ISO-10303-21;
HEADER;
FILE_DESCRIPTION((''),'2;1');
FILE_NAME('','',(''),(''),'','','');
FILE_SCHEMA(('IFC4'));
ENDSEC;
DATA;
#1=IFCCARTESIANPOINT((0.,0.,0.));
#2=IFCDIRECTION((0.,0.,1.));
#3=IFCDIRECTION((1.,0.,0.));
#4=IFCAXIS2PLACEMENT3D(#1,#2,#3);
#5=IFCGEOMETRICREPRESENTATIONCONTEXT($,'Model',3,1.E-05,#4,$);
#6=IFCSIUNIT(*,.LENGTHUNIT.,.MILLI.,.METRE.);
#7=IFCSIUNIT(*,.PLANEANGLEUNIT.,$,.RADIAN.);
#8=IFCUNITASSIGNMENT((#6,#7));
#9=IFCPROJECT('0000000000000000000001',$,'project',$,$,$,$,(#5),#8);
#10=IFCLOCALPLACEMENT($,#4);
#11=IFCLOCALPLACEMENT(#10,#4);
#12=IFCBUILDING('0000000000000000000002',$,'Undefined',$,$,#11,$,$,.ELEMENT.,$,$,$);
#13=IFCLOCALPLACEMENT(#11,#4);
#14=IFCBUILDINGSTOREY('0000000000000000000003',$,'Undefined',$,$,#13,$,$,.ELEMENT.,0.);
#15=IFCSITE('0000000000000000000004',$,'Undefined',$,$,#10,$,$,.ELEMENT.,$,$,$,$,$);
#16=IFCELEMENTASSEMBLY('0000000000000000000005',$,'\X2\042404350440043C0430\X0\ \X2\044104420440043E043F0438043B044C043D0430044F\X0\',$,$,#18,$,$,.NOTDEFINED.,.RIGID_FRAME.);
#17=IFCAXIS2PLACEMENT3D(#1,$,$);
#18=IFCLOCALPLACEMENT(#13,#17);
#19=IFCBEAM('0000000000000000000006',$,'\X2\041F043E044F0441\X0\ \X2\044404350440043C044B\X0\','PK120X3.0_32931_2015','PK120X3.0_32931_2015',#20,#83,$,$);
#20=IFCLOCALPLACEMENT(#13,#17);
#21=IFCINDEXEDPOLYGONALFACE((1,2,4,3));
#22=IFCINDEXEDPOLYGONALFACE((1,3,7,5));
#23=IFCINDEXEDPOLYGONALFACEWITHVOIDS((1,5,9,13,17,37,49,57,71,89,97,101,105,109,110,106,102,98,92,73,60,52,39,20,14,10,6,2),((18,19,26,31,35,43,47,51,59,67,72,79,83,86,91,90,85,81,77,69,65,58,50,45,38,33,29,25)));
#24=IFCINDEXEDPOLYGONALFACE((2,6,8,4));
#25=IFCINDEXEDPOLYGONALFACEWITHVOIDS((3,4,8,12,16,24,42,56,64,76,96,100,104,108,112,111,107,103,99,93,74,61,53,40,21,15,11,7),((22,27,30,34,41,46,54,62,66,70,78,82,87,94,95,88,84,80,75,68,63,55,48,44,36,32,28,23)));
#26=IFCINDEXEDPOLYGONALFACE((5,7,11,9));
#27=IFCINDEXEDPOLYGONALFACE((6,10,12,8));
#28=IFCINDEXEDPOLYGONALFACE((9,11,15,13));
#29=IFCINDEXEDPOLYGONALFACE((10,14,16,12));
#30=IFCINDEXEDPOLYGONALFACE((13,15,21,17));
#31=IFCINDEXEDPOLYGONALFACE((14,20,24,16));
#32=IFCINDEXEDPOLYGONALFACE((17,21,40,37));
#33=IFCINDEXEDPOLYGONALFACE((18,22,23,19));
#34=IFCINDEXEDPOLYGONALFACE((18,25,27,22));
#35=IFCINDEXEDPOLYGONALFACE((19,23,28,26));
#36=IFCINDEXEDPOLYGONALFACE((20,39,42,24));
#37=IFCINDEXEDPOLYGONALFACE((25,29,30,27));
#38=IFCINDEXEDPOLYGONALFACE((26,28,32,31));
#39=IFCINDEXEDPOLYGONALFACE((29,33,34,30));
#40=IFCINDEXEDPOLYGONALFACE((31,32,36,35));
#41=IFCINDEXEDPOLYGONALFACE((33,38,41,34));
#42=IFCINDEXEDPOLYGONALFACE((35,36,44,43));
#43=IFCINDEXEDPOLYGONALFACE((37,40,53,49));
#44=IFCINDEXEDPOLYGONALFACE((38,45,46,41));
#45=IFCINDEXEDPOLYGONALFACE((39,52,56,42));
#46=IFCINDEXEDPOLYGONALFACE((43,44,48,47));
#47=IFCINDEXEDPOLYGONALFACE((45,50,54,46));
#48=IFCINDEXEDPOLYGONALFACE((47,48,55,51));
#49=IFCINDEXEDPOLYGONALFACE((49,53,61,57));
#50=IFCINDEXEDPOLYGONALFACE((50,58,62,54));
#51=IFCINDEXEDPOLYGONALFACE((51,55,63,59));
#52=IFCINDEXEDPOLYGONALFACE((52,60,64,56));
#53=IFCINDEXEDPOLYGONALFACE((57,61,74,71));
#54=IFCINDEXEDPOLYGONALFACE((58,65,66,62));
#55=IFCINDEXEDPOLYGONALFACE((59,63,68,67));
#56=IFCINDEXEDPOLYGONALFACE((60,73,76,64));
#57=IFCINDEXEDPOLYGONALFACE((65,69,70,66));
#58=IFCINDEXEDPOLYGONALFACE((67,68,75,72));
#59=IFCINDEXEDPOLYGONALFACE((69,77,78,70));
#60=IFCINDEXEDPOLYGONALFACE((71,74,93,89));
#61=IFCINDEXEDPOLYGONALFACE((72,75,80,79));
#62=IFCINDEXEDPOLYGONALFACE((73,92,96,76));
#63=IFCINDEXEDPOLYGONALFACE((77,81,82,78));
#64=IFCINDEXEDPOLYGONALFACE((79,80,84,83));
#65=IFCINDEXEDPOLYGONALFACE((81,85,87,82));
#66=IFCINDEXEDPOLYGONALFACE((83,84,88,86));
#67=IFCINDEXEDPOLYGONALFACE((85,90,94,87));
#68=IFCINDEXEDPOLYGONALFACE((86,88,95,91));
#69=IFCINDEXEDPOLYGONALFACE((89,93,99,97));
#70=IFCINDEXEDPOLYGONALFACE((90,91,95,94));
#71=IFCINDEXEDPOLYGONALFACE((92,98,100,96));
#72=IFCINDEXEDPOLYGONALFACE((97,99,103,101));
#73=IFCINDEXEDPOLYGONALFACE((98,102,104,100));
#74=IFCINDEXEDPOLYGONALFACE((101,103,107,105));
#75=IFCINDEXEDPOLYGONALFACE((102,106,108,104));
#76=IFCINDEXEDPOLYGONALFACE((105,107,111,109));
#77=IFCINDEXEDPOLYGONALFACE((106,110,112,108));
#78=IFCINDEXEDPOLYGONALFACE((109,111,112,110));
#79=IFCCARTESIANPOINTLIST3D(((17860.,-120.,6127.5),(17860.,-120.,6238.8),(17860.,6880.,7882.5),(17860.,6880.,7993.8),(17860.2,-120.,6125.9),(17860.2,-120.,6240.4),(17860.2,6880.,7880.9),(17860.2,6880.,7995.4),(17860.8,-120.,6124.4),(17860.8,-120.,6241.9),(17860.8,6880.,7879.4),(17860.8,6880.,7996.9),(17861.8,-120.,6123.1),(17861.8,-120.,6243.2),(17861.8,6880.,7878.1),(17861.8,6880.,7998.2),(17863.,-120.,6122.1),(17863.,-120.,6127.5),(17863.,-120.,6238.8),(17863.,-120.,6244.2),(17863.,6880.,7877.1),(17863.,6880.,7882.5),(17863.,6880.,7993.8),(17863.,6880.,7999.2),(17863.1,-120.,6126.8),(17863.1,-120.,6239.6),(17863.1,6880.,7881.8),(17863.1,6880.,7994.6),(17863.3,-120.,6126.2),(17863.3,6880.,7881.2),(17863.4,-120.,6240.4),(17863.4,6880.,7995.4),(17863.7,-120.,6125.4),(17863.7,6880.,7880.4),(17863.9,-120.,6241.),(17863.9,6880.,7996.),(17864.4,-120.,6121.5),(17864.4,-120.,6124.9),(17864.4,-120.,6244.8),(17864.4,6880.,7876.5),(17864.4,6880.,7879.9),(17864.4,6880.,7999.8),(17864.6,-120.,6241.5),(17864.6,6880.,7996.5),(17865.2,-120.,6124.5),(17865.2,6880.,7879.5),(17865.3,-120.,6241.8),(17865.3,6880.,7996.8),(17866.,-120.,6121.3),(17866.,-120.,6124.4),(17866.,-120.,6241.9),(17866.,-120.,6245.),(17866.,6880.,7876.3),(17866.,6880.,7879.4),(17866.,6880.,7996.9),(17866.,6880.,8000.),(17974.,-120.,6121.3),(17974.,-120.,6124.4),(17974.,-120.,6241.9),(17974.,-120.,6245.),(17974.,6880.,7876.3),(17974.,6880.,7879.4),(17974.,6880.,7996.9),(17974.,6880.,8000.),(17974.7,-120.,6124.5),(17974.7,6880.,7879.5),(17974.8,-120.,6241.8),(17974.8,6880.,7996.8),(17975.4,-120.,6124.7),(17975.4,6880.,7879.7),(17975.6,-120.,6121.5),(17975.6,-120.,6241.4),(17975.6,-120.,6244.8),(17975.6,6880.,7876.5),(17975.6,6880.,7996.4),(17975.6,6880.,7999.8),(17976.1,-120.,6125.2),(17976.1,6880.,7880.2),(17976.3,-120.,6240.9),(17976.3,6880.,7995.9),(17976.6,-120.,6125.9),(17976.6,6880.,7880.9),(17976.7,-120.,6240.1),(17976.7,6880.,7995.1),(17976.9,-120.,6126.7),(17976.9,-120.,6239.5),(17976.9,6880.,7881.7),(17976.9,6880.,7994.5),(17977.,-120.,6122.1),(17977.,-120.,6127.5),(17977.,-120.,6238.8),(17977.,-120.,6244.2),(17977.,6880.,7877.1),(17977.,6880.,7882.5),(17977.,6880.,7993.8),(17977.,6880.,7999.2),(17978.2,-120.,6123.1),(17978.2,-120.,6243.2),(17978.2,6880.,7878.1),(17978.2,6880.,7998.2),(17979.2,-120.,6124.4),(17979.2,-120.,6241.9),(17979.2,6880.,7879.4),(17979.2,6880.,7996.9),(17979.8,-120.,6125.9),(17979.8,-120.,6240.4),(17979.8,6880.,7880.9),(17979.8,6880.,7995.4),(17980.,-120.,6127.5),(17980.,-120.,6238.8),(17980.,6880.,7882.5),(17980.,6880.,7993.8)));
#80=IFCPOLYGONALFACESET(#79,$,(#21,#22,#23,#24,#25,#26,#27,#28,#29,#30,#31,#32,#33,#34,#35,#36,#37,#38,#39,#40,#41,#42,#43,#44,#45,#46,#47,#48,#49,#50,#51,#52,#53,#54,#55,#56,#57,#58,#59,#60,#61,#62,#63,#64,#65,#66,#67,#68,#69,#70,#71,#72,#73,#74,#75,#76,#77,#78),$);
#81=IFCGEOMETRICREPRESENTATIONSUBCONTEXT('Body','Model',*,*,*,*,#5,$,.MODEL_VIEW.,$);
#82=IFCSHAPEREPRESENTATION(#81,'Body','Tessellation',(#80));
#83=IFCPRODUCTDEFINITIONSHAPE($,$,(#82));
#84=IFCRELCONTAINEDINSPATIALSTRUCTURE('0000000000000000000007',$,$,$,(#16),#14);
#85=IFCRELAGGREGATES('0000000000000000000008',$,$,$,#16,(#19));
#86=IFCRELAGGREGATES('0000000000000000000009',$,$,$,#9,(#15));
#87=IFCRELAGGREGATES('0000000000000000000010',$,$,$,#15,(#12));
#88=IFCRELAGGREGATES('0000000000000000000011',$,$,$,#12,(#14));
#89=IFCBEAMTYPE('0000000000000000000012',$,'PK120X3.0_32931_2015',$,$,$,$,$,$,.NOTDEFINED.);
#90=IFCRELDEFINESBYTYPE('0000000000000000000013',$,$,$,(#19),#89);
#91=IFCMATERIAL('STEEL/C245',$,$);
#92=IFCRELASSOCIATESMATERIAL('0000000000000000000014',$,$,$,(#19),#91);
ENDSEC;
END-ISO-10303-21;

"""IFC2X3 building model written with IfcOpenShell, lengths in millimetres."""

from ifc_helpers import new_model, si_unit, frame, origin_with_axes, origin_2d_with_axis, place, context, subcontext, project, spatial, hollow_rectangle, extrude, clip, halfspace, material, type_object, element, aggregate, save


model = new_model("IFC2X3")

# Units and contexts
model_context = context("Model", 3, precision=1e-05, world=origin_with_axes())
body_context = subcontext(model_context, "Body", "Model", "MODEL_VIEW")
ifc_project = project(units=[si_unit("LENGTHUNIT", "METRE", prefix="MILLI"), si_unit("PLANEANGLEUNIT", "RADIAN")], contexts=[model_context])

# Site, building, storey
site_placement = place(None, origin_with_axes())
site = spatial("IfcSite", under=ifc_project, at=site_placement, Name="Undefined", CompositionType="ELEMENT")
building_placement = place(site_placement, origin_with_axes())
building = spatial("IfcBuilding", under=site, at=building_placement, Name="Undefined", CompositionType="ELEMENT")
storey_placement = place(building_placement, origin_with_axes())
storey = spatial("IfcBuildingStorey", under=building, at=storey_placement, Name="Undefined", CompositionType="ELEMENT", Elevation=0.0)

# Shared definitions
ifc_material = material(Name="STEEL/C245")

# Element assembly
assembly_1_placement = place(storey_placement, origin_with_axes())
assembly_1 = element("IfcElementAssembly", 1, at=assembly_1_placement, inside=storey, Name="Ферма стропильная", AssemblyPlace="NOTDEFINED", PredefinedType="RIGID_FRAME")

# Beam
beam_type_1 = type_object("IfcBeamType", Name="PK120X3.0_32931_2015", PredefinedType="NOTDEFINED")
beam_1_placement = place(assembly_1_placement, frame((17920.0, -105.4, 6186.8), z_axis=(0.0, -0.243188, 0.969979), x_axis=(0.0, 0.969979, 0.243188)))
beam_1 = element("IfcBeam", 2, at=beam_1_placement, type_object=beam_type_1, material=ifc_material, Name="Пояс фермы", Description="PK120X3.0_32931_2015", ObjectType="PK120X3.0_32931_2015", context=body_context, shape_type="Clipping", body=[
    clip(clip(extrude(hollow_rectangle(XDim=120.0, YDim=120.0, WallThickness=3.0, InnerFilletRadius=3.0, OuterFilletRadius=6.0, at=origin_2d_with_axis()), frame((7232.0, 0.0, 0.0), z_axis=(-1.0, 0.0, 0.0), x_axis=(0.0, -1.0, 0.0)), (0.0, 0.0, 1.0), 7277.4), halfspace(frame((7216.6, 0.0, 60.0), z_axis=(0.969979, 0.0, -0.243188), x_axis=(0.0, -1.0, 0.0)), False)), halfspace(frame((0.0, 0.0, 60.0), z_axis=(0.969979, 0.0, -0.243188), x_axis=(0.0, -1.0, 0.0)), True)),
])
aggregate(assembly_1, [beam_1])

save(model, "model.ifc")
